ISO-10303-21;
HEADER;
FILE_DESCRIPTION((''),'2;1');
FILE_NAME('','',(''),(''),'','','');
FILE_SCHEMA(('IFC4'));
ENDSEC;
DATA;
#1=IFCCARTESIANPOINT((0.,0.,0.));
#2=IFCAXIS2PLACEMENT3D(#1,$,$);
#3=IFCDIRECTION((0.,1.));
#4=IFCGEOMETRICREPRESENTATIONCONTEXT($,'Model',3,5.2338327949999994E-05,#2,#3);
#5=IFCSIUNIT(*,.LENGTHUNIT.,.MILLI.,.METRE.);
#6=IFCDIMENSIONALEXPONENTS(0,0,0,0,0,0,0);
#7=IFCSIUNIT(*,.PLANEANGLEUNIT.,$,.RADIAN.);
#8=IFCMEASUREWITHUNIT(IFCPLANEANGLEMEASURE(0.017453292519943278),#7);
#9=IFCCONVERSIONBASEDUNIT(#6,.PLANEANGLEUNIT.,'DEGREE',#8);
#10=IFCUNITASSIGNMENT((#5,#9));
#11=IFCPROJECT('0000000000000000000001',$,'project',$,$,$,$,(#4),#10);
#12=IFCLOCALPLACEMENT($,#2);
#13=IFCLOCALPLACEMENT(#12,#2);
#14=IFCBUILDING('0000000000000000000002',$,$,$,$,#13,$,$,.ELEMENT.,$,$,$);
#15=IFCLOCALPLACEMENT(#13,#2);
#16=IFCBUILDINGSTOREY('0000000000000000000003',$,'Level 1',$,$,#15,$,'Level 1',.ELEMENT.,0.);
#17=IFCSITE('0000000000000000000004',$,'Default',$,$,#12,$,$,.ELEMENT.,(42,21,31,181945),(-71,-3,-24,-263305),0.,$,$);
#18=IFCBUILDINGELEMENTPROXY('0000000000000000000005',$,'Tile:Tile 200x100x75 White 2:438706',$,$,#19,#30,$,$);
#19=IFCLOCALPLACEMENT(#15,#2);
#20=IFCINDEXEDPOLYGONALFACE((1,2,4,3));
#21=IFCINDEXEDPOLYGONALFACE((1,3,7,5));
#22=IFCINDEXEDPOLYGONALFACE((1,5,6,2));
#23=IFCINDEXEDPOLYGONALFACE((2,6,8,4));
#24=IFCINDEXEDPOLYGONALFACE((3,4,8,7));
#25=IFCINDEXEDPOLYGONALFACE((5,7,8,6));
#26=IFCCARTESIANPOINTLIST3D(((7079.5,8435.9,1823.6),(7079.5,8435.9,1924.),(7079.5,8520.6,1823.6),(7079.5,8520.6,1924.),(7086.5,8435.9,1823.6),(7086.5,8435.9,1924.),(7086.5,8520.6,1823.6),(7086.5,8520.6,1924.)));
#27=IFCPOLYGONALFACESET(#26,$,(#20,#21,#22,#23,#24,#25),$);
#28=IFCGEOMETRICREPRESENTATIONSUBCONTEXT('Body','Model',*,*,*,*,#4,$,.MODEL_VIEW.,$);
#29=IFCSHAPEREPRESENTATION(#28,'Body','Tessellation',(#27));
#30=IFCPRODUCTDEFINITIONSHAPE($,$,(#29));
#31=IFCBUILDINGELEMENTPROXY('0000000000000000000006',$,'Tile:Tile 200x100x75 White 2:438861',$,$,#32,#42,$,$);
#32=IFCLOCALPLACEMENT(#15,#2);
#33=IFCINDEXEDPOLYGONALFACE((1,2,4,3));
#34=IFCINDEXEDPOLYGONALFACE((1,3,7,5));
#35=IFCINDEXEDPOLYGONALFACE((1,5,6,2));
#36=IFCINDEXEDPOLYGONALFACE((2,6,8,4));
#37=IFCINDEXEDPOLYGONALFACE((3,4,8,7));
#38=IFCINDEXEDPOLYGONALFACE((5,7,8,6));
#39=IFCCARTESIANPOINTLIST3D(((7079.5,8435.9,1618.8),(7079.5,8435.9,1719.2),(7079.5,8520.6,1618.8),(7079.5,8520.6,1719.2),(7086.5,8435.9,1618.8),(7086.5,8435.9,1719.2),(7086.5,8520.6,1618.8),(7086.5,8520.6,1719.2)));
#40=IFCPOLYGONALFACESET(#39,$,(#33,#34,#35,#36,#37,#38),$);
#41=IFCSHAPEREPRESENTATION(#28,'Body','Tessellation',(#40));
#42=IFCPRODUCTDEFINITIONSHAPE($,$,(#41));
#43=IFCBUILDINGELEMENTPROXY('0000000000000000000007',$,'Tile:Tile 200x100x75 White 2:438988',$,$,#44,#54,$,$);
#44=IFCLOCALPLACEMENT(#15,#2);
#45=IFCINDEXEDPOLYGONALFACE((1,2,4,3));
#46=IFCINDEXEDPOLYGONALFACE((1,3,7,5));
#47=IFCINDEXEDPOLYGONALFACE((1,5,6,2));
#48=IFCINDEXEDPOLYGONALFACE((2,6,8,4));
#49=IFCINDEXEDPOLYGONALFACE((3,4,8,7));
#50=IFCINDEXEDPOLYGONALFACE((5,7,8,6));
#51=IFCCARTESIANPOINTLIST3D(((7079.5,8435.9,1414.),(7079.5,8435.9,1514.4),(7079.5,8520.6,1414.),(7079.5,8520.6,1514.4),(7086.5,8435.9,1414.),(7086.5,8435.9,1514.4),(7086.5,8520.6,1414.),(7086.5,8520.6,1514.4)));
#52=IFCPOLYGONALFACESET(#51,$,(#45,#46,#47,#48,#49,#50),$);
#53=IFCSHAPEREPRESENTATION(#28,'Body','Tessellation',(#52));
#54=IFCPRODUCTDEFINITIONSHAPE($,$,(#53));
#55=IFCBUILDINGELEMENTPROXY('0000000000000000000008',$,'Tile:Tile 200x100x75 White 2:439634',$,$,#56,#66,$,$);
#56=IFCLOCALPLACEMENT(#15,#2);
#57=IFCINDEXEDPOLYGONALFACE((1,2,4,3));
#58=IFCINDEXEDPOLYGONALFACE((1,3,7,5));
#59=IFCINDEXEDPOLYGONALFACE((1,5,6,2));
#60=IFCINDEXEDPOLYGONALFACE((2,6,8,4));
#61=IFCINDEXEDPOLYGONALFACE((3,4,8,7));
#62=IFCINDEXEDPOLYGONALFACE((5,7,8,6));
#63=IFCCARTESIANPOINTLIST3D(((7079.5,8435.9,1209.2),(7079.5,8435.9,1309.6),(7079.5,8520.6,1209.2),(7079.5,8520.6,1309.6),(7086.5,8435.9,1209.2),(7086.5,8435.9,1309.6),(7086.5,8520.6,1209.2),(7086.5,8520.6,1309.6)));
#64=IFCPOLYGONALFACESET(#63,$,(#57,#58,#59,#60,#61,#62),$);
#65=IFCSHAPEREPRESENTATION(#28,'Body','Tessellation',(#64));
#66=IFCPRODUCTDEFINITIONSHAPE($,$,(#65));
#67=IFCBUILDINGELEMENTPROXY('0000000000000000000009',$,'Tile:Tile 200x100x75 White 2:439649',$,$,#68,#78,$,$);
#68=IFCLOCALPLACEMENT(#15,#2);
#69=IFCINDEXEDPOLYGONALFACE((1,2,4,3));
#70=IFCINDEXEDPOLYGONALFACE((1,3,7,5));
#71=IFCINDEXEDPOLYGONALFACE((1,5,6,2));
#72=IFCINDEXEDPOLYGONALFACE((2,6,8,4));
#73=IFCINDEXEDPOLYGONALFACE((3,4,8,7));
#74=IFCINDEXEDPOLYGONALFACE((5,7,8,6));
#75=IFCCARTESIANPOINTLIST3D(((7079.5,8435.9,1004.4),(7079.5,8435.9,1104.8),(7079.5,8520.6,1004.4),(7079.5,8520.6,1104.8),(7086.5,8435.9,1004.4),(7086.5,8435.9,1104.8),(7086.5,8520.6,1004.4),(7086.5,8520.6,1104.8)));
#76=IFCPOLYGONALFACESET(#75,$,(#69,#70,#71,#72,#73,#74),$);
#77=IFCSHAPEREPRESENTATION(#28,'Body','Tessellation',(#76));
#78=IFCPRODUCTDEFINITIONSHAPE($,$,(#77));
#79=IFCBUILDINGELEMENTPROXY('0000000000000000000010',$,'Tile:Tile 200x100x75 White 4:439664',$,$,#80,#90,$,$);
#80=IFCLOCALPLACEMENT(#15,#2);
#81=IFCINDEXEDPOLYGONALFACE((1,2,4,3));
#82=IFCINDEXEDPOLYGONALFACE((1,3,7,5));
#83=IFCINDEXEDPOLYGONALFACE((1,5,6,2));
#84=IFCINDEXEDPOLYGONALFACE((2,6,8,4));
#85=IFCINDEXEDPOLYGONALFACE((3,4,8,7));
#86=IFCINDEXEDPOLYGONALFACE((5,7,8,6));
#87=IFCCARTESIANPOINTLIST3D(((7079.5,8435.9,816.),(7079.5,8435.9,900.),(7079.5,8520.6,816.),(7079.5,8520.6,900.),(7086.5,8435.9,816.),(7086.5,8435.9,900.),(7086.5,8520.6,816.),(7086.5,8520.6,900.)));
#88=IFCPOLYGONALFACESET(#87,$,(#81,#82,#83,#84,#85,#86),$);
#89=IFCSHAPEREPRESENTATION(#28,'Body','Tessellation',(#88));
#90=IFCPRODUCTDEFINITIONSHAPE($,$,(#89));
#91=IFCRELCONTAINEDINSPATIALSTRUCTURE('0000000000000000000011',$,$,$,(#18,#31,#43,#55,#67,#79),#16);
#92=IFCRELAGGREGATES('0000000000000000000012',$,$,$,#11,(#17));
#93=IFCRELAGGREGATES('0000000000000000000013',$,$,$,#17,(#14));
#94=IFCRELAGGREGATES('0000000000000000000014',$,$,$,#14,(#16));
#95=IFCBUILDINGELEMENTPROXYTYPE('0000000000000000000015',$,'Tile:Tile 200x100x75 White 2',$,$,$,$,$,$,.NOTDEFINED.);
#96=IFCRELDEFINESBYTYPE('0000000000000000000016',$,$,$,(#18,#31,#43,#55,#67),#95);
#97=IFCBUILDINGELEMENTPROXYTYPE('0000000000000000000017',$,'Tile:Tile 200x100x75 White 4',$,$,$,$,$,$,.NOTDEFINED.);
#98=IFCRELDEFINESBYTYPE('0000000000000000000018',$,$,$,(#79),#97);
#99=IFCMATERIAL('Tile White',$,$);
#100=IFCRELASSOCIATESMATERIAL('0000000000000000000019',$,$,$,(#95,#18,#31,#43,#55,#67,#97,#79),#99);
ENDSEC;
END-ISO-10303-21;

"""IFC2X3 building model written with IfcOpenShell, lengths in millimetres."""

from ifc_helpers import new_model, entity, si_unit, converted_unit, direction, frame, frame_2d, origin, origin_2d_with_axis, place, context, subcontext, project, spatial, rectangle, extrude, source, transform, mapped, material, type_object, type_shapes, element, save


model = new_model("IFC2X3")

# Units and contexts
model_context = context("Model", 3, precision=5.2338327949999994e-05, world=origin(), true_north=direction((0.0, 1.0)))
body_context = subcontext(model_context, "Body", "Model", "MODEL_VIEW")
ifc_project = project(units=[si_unit("LENGTHUNIT", "METRE", prefix="MILLI"), converted_unit("PLANEANGLEUNIT", "DEGREE", entity("IfcPlaneAngleMeasure", 0.017453292519943278), si_unit("PLANEANGLEUNIT", "RADIAN"), dimensions=[0, 0, 0, 0, 0, 0, 0])], contexts=[model_context])

# Site, building, storey
site_placement = place(None, origin())
site = spatial("IfcSite", under=ifc_project, at=site_placement, Name="Default", CompositionType="ELEMENT", RefLatitude=(42, 21, 31, 181945), RefLongitude=(-71, -3, -24, -263305), RefElevation=0.0)
building_placement = place(site_placement, origin())
building = spatial("IfcBuilding", under=site, at=building_placement, CompositionType="ELEMENT")
storey_placement = place(building_placement, origin())
storey = spatial("IfcBuildingStorey", under=building, at=storey_placement, Name="Level 1", LongName="Level 1", CompositionType="ELEMENT", Elevation=0.0)

# Building element proxies
ifc_material_1 = material(Name="Tile White")
building_element_proxy_type_1 = type_object("IfcBuildingElementProxyType", Name="Tile:Tile 200x100x75 White 2", PredefinedType="NOTDEFINED", material=ifc_material_1)
shared_shape_1 = source(origin(), body_context, "Body", "SweptSolid", [
    extrude(rectangle(XDim=84.7, YDim=100.4, at=frame_2d((0.0, 0.0), x_axis=(1.0, 0.0))), frame((-50.2, -42.4, 0.0), z_axis=(0.0, 0.0, 1.0), x_axis=(0.0, -1.0, 0.0)), (0.0, 0.0, 1.0), 7.0),
])
type_shapes(building_element_proxy_type_1, [shared_shape_1])
for number, where, z_axis, x_axis, name in (
    (1, (7086.5, 8520.6, 1924.0), (-1.0, 0.0, 0.0), (0.0, 0.0, 1.0), "Tile:Tile 200x100x75 White 2:438706"),
    (2, (7086.5, 8520.6, 1719.2), (-1.0, 0.0, 0.0), (0.0, 0.0, 1.0), "Tile:Tile 200x100x75 White 2:438861"),
    (3, (7086.5, 8520.6, 1514.4), (-1.0, 0.0, 0.0), (0.0, 0.0, 1.0), "Tile:Tile 200x100x75 White 2:438988"),
    (4, (7086.5, 8520.6, 1309.6), (-1.0, 0.0, 0.0), (0.0, 0.0, 1.0), "Tile:Tile 200x100x75 White 2:439634"),
    (5, (7086.5, 8520.6, 1104.8), (-1.0, 0.0, 0.0), (0.0, 0.0, 1.0), "Tile:Tile 200x100x75 White 2:439649"),
):
    element("IfcBuildingElementProxy", number, at=place(storey_placement, frame(where, z_axis=z_axis, x_axis=x_axis)), inside=storey, type_object=building_element_proxy_type_1, material=ifc_material_1, Name=name, context=body_context, shape_type="MappedRepresentation", body=[
        mapped(shared_shape_1, transform((0.0, 0.0, 0.0), scale=1.0)),
    ])
building_element_proxy_type_2 = type_object("IfcBuildingElementProxyType", Name="Tile:Tile 200x100x75 White 4", PredefinedType="NOTDEFINED", material=ifc_material_1)
shared_shape_2 = source(origin(), body_context, "Body", "SweptSolid", [
    extrude(rectangle(XDim=84.7, YDim=84.0, at=origin_2d_with_axis()), frame((-42.0, -42.4, 0.0), z_axis=(0.0, 0.0, 1.0), x_axis=(0.0, -1.0, 0.0)), (0.0, 0.0, 1.0), 7.0),
])
type_shapes(building_element_proxy_type_2, [shared_shape_2])
proxy_1_placement = place(storey_placement, frame((7086.5, 8520.6, 900.0), z_axis=(-1.0, 0.0, 0.0), x_axis=(0.0, 0.0, 1.0)))
element("IfcBuildingElementProxy", 6, at=proxy_1_placement, inside=storey, type_object=building_element_proxy_type_2, material=ifc_material_1, Name="Tile:Tile 200x100x75 White 4:439664", context=body_context, shape_type="MappedRepresentation", body=[
    mapped(shared_shape_2, transform((0.0, 0.0, 0.0), scale=1.0)),
])

save(model, "model.ifc")
